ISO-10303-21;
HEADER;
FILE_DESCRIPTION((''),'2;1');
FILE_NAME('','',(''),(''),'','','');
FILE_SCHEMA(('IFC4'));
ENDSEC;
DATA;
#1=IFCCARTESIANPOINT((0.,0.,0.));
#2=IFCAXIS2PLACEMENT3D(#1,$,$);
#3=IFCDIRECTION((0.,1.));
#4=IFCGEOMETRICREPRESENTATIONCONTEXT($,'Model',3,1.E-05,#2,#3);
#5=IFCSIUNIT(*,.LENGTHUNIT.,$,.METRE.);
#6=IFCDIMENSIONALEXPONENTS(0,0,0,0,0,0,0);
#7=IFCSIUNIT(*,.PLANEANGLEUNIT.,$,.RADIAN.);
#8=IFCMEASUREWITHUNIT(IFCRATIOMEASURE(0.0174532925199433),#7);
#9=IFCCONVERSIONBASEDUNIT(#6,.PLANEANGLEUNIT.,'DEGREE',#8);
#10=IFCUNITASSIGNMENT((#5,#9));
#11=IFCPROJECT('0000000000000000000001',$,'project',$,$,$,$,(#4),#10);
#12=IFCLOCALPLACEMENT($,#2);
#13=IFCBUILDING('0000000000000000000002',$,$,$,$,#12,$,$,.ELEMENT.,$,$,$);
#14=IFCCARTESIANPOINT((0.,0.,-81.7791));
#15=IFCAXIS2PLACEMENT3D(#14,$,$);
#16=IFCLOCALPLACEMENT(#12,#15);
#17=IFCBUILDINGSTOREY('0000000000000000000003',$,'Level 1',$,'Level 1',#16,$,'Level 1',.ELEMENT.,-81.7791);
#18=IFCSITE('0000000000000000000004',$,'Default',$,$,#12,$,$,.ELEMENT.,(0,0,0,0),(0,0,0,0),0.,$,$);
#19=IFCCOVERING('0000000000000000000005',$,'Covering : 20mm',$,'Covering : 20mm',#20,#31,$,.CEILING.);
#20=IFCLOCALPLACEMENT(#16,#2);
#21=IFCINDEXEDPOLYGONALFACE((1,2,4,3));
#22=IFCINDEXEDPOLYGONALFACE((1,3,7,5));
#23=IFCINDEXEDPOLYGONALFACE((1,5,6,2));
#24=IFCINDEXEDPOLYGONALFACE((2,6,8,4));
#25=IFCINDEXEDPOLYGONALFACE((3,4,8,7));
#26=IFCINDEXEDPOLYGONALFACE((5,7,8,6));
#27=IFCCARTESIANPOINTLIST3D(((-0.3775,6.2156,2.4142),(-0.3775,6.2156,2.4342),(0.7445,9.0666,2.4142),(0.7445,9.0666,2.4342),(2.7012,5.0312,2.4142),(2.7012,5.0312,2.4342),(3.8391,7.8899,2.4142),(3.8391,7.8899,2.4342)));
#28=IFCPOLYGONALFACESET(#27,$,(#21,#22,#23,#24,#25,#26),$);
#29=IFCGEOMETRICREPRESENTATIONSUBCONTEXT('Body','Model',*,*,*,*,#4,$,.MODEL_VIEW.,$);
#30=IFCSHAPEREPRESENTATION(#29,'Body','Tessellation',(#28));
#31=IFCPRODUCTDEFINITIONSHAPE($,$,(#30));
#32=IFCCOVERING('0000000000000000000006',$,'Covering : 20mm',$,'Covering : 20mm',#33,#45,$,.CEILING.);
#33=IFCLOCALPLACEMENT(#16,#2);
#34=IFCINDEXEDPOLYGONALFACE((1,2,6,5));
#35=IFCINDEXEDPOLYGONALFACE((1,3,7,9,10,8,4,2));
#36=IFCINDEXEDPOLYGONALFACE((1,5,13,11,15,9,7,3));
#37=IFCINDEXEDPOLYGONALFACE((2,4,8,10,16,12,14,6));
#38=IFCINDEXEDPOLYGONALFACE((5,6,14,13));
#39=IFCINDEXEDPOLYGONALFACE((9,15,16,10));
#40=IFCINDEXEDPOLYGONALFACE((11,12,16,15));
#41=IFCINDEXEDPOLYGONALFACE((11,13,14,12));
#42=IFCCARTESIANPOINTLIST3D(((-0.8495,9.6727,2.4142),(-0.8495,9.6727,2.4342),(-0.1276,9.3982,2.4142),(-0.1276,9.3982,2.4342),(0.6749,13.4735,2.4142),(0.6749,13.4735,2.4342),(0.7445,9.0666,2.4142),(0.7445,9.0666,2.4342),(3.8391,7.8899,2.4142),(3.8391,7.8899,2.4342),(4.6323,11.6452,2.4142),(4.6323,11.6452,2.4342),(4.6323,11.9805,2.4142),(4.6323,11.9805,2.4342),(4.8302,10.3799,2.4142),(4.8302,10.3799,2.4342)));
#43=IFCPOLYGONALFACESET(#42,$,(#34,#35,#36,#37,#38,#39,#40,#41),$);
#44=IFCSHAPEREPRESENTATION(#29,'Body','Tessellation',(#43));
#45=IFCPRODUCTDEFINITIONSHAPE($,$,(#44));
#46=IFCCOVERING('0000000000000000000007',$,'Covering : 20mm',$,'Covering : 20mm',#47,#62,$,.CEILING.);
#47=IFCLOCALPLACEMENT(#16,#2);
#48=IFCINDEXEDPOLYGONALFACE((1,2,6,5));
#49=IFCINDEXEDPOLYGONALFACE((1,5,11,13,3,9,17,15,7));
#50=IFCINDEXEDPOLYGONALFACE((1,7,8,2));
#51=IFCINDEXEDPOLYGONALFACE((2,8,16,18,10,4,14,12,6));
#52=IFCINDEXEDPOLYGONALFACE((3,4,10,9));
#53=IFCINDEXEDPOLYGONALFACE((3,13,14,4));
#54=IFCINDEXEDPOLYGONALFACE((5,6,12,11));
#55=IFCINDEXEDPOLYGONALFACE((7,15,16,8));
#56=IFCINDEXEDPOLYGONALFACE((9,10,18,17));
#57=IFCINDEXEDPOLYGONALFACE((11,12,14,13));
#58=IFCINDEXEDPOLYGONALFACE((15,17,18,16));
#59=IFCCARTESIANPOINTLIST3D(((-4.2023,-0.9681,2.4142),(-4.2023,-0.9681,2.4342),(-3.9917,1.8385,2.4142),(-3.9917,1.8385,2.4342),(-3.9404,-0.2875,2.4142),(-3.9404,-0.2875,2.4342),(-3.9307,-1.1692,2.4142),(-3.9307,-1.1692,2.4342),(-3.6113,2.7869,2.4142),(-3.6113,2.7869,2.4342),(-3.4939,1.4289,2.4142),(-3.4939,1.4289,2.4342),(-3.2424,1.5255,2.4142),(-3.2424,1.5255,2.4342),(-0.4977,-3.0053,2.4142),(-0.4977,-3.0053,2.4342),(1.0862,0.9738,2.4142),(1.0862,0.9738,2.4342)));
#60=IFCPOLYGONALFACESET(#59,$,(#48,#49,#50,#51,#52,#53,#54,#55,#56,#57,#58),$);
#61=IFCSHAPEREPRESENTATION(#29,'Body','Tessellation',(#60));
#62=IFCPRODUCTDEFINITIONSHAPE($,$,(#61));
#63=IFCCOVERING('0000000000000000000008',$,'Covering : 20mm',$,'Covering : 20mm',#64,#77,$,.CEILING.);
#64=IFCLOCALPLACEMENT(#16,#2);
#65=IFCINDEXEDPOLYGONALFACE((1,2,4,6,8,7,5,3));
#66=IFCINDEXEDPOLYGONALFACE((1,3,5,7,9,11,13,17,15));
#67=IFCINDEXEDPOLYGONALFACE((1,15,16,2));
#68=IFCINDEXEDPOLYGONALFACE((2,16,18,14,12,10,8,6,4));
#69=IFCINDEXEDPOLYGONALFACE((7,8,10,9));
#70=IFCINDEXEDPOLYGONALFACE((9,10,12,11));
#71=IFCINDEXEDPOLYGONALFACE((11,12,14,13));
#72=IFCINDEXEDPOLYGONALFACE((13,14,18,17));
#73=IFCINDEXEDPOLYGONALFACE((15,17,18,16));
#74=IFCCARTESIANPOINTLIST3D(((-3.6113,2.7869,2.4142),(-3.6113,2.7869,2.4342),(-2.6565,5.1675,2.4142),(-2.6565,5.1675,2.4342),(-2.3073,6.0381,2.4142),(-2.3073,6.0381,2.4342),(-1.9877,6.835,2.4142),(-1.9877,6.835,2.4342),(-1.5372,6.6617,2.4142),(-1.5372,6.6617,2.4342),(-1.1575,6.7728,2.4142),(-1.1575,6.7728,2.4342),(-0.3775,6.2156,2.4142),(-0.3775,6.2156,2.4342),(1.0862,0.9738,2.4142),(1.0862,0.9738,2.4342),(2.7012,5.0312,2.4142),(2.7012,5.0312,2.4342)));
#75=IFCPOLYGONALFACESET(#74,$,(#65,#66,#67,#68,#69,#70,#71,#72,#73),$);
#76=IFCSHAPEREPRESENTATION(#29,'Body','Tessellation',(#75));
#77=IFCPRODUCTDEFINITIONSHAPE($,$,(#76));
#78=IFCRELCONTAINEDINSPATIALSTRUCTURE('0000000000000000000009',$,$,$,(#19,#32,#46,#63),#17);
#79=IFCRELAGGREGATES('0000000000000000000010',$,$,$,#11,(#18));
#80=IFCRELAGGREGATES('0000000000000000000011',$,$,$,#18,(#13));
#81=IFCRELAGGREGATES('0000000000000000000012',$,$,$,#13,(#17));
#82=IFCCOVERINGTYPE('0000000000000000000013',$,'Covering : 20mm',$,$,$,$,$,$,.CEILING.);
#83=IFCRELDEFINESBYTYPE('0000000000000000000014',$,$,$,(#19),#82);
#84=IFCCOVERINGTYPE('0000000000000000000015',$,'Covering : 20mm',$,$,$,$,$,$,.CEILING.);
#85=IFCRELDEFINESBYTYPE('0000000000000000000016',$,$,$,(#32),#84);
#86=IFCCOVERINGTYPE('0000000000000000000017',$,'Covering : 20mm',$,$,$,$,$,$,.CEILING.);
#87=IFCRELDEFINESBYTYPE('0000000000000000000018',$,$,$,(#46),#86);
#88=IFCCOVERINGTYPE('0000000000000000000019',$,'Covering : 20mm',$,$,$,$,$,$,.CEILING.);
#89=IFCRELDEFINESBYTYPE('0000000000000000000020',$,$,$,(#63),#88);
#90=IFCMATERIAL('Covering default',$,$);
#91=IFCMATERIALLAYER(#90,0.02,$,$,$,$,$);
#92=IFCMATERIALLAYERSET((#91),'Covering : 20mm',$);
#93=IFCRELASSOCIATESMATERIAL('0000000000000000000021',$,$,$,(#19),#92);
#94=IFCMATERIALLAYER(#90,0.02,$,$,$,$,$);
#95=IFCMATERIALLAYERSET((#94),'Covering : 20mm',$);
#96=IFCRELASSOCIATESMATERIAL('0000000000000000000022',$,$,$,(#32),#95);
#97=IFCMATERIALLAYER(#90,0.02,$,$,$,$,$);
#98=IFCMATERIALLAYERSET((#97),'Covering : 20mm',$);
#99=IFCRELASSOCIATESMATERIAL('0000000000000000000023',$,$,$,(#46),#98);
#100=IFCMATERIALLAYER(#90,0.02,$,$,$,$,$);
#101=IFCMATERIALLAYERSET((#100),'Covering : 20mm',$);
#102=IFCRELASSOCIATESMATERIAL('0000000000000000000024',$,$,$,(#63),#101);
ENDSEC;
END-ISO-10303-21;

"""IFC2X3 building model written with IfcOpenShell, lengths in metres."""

from ifc_helpers import new_model, entity, si_unit, converted_unit, direction, frame, origin, origin_with_axes, place, context, subcontext, project, spatial, polyline, outline, extrude, material, layer, layer_set, layer_usage, type_object, element, save


model = new_model("IFC2X3")

# Units and contexts
model_context = context("Model", 3, precision=1e-05, world=origin(), true_north=direction((0.0, 1.0)))
body_context = subcontext(model_context, "Body", "Model", "MODEL_VIEW")
ifc_project = project(units=[si_unit("LENGTHUNIT", "METRE"), converted_unit("PLANEANGLEUNIT", "DEGREE", entity("IfcRatioMeasure", 0.0174532925199433), si_unit("PLANEANGLEUNIT", "RADIAN"), dimensions=[0, 0, 0, 0, 0, 0, 0])], contexts=[model_context])

# Site, building, storey
placement = place(None, origin())
site = spatial("IfcSite", under=ifc_project, at=placement, Name="Default", CompositionType="ELEMENT", RefLatitude=(0, 0, 0, 0), RefLongitude=(0, 0, 0, 0), RefElevation=0.0)
building = spatial("IfcBuilding", under=site, at=placement, CompositionType="ELEMENT")
storey_placement = place(placement, frame((0.0, 0.0, -81.7791)))
storey = spatial("IfcBuildingStorey", under=building, at=storey_placement, Name="Level 1", ObjectType="Level 1", LongName="Level 1", CompositionType="ELEMENT", Elevation=-81.7791)

# Coverings
ifc_material_1 = material(Name="Covering default")
ifc_layer_1 = layer(ifc_material_1, 0.02)
ifc_layer_set_1 = layer_set([ifc_layer_1], Name="Covering : 20mm")
ifc_layer_usage_1 = layer_usage(ifc_layer_set_1, "AXIS3", "POSITIVE", 0.0)
covering_type_1 = type_object("IfcCoveringType", Name="Covering : 20mm", PredefinedType="CEILING")
covering_1_placement = place(placement, frame((0.0, 0.0, -79.3649)))
element("IfcCovering", 1, at=covering_1_placement, inside=storey, type_object=covering_type_1, material=ifc_layer_usage_1, Name="Covering : 20mm", ObjectType="Covering : 20mm", PredefinedType="CEILING", context=body_context, shape_type="SweptSolid", body=[
    extrude(outline(polyline([(3.8391, 7.8899), (2.7012, 5.0312), (-0.3775, 6.2156), (0.7445, 9.0666), (3.8391, 7.8899)])), origin_with_axes(), (0.0, 0.0, 1.0), 0.02),
])
ifc_layer_2 = layer(ifc_material_1, 0.02)
ifc_layer_set_2 = layer_set([ifc_layer_2], Name="Covering : 20mm")
ifc_layer_usage_2 = layer_usage(ifc_layer_set_2, "AXIS3", "POSITIVE", 0.0)
covering_type_2 = type_object("IfcCoveringType", Name="Covering : 20mm", PredefinedType="CEILING")
covering_2_placement = place(placement, frame((0.0, 0.0, -79.3649)))
element("IfcCovering", 2, at=covering_2_placement, inside=storey, type_object=covering_type_2, material=ifc_layer_usage_2, Name="Covering : 20mm", ObjectType="Covering : 20mm", PredefinedType="CEILING", context=body_context, shape_type="SweptSolid", body=[
    extrude(outline(polyline([(0.7445, 9.0666), (3.8391, 7.8899), (4.8302, 10.3799), (4.6323, 11.6452), (4.6323, 11.9805), (0.6749, 13.4735), (-0.8495, 9.6727), (-0.1276, 9.3982), (0.7445, 9.0666)])), origin_with_axes(), (0.0, 0.0, 1.0), 0.02),
])
ifc_layer_3 = layer(ifc_material_1, 0.02)
ifc_layer_set_3 = layer_set([ifc_layer_3], Name="Covering : 20mm")
ifc_layer_usage_3 = layer_usage(ifc_layer_set_3, "AXIS3", "POSITIVE", 0.0)
covering_type_3 = type_object("IfcCoveringType", Name="Covering : 20mm", PredefinedType="CEILING")
covering_3_placement = place(placement, frame((0.0, 0.0, -79.3649)))
element("IfcCovering", 3, at=covering_3_placement, inside=storey, type_object=covering_type_3, material=ifc_layer_usage_3, Name="Covering : 20mm", ObjectType="Covering : 20mm", PredefinedType="CEILING", context=body_context, shape_type="SweptSolid", body=[
    extrude(outline(polyline([(-0.4977, -3.0053), (1.0862, 0.9738), (-3.6113, 2.7869), (-3.9917, 1.8385), (-3.2424, 1.5255), (-3.4939, 1.4289), (-3.9404, -0.2875), (-4.2023, -0.9681), (-3.9307, -1.1692), (-0.4977, -3.0053)])), origin_with_axes(), (0.0, 0.0, 1.0), 0.02),
])
ifc_layer_4 = layer(ifc_material_1, 0.02)
ifc_layer_set_4 = layer_set([ifc_layer_4], Name="Covering : 20mm")
ifc_layer_usage_4 = layer_usage(ifc_layer_set_4, "AXIS3", "POSITIVE", 0.0)
covering_type_4 = type_object("IfcCoveringType", Name="Covering : 20mm", PredefinedType="CEILING")
covering_4_placement = place(placement, frame((0.0, 0.0, -79.3649)))
element("IfcCovering", 4, at=covering_4_placement, inside=storey, type_object=covering_type_4, material=ifc_layer_usage_4, Name="Covering : 20mm", ObjectType="Covering : 20mm", PredefinedType="CEILING", context=body_context, shape_type="SweptSolid", body=[
    extrude(outline(polyline([(2.7012, 5.0312), (1.0862, 0.9738), (-3.6113, 2.7869), (-2.6565, 5.1675), (-2.3073, 6.0381), (-1.9877, 6.835), (-1.5372, 6.6617), (-1.1575, 6.7728), (-0.3775, 6.2156), (2.7012, 5.0312)])), origin_with_axes(), (0.0, 0.0, 1.0), 0.02),
])

save(model, "model.ifc")
